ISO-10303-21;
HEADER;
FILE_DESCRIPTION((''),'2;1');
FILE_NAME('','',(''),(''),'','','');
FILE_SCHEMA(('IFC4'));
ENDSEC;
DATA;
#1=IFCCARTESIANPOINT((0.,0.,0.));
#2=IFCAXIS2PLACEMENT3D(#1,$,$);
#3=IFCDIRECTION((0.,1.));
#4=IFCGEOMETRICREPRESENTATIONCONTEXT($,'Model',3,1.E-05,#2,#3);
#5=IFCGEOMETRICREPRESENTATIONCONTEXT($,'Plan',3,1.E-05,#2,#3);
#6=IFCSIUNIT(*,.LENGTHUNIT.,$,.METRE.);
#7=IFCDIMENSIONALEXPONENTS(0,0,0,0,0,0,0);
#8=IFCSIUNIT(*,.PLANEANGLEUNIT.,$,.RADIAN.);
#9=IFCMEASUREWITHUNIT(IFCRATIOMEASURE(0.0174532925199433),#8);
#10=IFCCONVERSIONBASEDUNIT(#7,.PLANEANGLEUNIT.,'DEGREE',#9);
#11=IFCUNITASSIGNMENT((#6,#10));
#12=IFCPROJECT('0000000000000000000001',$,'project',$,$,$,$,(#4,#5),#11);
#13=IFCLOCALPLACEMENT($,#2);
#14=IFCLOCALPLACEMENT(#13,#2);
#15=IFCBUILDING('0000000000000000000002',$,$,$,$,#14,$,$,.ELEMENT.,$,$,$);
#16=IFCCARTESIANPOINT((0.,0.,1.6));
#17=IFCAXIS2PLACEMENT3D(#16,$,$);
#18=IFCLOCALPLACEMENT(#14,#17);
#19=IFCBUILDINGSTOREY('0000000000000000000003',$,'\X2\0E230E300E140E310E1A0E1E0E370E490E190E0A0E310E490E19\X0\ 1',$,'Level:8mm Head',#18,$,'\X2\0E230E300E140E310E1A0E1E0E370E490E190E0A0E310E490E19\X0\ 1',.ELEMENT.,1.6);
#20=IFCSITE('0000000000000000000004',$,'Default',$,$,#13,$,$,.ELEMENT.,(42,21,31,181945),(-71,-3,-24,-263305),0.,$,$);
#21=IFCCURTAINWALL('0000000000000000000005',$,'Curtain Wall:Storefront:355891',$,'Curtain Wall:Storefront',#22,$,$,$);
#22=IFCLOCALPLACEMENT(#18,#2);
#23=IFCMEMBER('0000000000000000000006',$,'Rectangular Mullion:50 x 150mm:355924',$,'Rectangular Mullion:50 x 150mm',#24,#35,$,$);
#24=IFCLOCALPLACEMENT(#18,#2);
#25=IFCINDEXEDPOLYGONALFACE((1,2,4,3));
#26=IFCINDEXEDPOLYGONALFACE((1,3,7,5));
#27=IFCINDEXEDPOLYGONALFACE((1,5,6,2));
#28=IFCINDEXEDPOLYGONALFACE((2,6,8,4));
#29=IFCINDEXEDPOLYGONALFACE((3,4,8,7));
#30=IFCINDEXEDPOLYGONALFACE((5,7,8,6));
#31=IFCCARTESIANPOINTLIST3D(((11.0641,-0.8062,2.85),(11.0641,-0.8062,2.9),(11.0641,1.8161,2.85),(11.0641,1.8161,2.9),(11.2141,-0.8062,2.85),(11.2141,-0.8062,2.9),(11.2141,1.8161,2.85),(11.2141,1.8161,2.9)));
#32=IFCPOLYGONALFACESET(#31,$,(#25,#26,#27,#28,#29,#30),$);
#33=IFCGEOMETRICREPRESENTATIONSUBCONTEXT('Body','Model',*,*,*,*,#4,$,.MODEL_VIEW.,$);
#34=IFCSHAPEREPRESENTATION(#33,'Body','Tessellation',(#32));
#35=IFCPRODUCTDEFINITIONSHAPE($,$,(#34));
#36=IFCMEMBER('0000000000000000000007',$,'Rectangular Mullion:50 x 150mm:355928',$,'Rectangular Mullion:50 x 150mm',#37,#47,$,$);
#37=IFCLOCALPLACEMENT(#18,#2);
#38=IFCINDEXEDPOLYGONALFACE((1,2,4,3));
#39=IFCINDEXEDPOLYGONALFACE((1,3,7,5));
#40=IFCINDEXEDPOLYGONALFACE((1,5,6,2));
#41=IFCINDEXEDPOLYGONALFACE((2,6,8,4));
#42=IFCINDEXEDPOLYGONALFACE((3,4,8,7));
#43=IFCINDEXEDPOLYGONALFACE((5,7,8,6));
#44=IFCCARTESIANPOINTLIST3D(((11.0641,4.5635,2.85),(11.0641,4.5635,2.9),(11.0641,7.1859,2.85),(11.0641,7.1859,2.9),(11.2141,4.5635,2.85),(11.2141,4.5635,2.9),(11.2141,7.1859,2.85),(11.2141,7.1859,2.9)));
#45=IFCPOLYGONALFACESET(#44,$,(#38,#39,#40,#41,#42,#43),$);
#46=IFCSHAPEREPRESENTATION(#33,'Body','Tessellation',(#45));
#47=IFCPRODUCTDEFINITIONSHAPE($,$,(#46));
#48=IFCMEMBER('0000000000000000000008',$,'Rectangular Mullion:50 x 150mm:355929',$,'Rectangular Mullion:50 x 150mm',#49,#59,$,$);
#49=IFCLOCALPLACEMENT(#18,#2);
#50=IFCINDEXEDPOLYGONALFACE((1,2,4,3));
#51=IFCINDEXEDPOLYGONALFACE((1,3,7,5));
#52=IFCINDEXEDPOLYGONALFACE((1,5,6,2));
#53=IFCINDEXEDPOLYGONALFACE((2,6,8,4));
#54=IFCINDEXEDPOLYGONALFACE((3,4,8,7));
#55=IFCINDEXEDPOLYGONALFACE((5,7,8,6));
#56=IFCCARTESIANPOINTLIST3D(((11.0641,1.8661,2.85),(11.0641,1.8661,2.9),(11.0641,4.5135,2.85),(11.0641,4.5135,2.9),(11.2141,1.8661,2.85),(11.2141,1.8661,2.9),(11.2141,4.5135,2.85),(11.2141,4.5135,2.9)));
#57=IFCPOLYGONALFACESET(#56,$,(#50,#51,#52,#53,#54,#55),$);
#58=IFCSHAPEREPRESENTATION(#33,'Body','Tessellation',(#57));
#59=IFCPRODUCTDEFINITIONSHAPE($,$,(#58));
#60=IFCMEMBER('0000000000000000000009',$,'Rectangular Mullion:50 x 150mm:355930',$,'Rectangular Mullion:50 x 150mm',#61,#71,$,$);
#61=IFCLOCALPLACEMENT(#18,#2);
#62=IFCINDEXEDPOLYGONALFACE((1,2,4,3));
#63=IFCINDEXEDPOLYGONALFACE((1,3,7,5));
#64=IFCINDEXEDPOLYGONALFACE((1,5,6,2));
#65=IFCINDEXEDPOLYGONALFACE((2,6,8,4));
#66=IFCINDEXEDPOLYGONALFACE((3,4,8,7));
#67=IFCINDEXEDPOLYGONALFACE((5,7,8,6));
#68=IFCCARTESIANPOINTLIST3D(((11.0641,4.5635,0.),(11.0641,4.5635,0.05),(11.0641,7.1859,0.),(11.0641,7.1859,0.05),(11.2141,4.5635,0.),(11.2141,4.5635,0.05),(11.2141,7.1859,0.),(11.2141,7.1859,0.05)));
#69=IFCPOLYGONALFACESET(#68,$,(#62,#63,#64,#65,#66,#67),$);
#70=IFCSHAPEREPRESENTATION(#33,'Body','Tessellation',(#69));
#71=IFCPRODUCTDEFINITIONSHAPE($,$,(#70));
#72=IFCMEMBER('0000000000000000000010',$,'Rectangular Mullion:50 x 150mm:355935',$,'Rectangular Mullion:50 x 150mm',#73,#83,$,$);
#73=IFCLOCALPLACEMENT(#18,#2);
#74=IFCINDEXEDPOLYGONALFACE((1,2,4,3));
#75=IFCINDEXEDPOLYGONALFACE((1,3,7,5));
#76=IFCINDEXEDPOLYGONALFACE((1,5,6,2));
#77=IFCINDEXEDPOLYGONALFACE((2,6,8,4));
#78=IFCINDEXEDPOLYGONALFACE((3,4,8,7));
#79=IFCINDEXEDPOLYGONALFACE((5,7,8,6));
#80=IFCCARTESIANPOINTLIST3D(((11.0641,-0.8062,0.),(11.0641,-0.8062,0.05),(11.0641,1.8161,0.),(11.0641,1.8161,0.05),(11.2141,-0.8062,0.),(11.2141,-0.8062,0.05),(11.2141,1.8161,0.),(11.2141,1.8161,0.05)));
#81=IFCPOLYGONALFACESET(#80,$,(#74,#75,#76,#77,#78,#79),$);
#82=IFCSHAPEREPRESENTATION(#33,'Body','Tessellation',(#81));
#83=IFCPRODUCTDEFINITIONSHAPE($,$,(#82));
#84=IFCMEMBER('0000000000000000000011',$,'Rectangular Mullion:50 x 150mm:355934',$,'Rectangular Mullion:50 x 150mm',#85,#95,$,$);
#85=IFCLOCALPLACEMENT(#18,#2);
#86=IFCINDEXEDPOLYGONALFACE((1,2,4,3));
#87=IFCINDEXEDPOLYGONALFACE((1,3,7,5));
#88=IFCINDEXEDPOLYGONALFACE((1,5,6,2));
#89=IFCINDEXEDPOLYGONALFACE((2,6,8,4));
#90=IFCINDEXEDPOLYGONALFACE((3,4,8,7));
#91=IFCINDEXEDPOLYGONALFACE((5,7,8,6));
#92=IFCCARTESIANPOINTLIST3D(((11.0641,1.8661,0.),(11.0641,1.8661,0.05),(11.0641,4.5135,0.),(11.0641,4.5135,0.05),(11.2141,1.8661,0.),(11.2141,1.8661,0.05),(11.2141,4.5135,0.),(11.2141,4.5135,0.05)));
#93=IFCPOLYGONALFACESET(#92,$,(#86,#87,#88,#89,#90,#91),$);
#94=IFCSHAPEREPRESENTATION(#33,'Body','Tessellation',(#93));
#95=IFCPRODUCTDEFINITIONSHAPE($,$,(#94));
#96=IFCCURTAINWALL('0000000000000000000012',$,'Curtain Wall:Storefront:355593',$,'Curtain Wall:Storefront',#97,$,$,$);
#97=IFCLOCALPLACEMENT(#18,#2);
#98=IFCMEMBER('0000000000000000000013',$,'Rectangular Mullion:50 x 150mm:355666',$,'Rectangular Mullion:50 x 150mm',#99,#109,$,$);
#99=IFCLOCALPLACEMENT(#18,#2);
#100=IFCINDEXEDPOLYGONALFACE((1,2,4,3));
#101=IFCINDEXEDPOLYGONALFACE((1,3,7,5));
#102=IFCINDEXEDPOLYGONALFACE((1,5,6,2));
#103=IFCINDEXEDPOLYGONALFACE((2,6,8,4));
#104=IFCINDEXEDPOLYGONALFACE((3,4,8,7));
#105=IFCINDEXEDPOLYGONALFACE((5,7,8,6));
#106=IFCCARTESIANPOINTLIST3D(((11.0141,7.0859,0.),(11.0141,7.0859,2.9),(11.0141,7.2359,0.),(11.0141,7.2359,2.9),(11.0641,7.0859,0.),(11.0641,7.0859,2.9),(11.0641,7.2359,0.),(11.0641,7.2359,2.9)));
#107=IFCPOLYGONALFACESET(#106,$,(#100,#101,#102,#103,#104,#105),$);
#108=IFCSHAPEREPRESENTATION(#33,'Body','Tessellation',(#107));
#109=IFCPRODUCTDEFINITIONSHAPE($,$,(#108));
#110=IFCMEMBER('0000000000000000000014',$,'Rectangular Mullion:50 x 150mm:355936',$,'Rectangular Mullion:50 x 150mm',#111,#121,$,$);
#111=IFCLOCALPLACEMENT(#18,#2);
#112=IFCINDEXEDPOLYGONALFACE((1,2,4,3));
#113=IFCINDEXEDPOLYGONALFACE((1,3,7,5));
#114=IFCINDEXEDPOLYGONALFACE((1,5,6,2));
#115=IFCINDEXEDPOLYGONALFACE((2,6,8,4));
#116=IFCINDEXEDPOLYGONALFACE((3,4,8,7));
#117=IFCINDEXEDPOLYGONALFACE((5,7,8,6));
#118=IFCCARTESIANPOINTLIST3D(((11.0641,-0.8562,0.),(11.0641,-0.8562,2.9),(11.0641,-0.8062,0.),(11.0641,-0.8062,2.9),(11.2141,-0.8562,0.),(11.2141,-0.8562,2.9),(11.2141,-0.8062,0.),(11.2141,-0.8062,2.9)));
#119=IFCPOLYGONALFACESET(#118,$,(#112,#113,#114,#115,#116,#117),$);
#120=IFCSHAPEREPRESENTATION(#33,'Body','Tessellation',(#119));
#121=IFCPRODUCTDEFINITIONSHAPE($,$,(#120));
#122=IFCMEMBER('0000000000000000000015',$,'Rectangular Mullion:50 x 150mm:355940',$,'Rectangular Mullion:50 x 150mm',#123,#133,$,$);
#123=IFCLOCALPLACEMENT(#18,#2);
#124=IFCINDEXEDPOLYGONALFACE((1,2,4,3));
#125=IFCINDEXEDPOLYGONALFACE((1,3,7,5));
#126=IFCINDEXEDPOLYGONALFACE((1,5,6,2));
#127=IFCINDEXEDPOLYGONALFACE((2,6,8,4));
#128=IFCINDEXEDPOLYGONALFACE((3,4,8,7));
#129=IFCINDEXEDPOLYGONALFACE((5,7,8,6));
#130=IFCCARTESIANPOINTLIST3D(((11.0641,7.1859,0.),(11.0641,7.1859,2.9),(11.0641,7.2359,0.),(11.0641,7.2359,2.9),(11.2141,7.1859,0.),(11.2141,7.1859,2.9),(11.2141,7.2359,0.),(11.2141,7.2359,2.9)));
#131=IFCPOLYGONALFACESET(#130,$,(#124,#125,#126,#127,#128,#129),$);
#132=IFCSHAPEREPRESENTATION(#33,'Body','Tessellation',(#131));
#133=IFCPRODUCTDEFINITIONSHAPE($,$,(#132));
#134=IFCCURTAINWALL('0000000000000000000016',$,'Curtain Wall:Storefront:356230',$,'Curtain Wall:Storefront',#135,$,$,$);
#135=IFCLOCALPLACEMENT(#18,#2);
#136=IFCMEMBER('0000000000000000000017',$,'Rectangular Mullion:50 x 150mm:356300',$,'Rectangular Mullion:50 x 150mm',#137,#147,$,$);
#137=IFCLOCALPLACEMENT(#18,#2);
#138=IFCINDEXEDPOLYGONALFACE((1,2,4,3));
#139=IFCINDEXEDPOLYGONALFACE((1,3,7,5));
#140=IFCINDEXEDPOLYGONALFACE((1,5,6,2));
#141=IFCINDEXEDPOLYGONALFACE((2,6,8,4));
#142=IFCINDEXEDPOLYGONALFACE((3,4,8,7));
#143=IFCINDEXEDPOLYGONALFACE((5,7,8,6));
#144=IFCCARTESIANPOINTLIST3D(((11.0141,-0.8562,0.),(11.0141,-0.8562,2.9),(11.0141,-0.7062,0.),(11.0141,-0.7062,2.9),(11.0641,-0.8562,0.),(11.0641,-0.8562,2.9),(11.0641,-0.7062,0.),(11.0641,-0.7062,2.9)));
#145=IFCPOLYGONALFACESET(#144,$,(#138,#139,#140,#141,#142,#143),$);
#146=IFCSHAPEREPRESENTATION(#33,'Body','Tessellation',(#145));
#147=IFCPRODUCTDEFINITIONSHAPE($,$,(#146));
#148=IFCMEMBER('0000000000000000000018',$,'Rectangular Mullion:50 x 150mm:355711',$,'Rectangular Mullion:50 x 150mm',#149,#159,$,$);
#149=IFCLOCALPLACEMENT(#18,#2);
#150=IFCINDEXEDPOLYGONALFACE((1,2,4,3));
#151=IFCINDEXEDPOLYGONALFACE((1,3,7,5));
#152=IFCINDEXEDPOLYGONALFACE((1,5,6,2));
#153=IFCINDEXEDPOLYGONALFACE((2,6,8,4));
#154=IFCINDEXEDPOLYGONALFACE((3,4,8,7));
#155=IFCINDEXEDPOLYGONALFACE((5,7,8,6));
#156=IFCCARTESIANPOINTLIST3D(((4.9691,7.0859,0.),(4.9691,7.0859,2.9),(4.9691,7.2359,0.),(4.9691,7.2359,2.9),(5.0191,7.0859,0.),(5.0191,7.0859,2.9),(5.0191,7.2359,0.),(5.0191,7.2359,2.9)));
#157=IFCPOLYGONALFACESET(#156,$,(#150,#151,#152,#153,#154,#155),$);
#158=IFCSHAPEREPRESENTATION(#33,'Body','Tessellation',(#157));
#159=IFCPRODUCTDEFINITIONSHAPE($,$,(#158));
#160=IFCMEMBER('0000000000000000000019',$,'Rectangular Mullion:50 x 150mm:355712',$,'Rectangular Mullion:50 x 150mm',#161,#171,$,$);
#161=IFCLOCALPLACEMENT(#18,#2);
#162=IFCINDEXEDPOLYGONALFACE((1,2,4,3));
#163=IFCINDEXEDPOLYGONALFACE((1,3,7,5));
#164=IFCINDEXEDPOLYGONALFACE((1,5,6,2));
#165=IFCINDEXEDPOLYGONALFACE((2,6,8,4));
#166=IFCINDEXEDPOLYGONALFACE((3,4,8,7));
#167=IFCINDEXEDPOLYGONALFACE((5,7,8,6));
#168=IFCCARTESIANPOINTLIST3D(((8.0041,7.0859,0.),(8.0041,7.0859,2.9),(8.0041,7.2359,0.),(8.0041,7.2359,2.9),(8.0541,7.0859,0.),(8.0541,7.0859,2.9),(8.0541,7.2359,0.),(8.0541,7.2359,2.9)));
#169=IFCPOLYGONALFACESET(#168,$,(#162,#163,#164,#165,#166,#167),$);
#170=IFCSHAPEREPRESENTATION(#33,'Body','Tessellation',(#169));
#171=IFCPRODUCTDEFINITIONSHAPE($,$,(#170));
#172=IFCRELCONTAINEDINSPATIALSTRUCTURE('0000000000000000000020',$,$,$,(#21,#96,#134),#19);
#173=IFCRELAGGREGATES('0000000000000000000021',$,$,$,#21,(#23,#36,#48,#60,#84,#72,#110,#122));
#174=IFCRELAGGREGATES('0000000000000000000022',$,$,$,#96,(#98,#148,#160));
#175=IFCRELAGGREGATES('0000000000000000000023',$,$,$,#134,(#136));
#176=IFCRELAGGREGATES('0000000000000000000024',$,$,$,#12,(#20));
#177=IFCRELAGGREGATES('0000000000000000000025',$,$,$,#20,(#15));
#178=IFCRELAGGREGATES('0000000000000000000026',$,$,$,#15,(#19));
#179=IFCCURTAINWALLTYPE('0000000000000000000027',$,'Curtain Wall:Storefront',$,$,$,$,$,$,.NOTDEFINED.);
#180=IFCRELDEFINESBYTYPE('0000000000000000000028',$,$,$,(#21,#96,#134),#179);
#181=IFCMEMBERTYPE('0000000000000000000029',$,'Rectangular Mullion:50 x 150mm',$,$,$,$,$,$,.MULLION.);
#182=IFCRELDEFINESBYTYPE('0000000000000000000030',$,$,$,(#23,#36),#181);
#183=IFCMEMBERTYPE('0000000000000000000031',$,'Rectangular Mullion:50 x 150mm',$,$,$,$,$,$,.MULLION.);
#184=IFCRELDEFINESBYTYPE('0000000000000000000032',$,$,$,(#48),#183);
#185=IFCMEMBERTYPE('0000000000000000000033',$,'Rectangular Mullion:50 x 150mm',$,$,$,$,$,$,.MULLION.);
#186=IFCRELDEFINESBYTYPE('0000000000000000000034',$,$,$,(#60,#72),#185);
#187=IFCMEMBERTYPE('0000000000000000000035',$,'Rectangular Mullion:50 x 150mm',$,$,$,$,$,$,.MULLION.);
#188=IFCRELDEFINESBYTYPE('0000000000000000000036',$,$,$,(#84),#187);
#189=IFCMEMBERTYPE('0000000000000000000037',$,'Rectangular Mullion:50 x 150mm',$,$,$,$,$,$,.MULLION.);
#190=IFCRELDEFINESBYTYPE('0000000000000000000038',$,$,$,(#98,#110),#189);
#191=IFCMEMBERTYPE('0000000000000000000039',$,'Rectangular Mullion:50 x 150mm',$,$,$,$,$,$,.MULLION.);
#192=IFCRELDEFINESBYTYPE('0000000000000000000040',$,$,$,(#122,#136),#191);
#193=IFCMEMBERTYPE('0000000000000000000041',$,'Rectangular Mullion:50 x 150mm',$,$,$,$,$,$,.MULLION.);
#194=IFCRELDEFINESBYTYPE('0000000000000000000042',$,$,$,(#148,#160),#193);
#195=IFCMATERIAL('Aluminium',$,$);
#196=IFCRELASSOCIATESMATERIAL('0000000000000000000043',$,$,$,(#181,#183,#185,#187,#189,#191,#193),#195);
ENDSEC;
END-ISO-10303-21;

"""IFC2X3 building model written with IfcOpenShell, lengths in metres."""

from ifc_helpers import new_model, entity, si_unit, converted_unit, direction, frame, origin, origin_2d_with_axis, place, context, subcontext, project, spatial, rectangle, extrude, source, transform, mapped, material, type_object, type_shapes, element, aggregate, save


model = new_model("IFC2X3")

# Units and contexts
model_context = context("Model", 3, precision=1e-05, world=origin(), true_north=direction((0.0, 1.0)))
plan_context = context("Plan", 3, precision=1e-05, world=origin(), true_north=direction((0.0, 1.0)))
body_context = subcontext(model_context, "Body", "Model", "MODEL_VIEW")
ifc_project = project(units=[si_unit("LENGTHUNIT", "METRE"), converted_unit("PLANEANGLEUNIT", "DEGREE", entity("IfcRatioMeasure", 0.0174532925199433), si_unit("PLANEANGLEUNIT", "RADIAN"), dimensions=[0, 0, 0, 0, 0, 0, 0])], contexts=[model_context, plan_context])

# Site, building, storey
site_placement = place(None, origin())
site = spatial("IfcSite", under=ifc_project, at=site_placement, Name="Default", CompositionType="ELEMENT", RefLatitude=(42, 21, 31, 181945), RefLongitude=(-71, -3, -24, -263305), RefElevation=0.0)
building_placement = place(site_placement, origin())
building = spatial("IfcBuilding", under=site, at=building_placement, CompositionType="ELEMENT")
storey_placement = place(building_placement, frame((0.0, 0.0, 1.6)))
storey = spatial("IfcBuildingStorey", under=building, at=storey_placement, Name="ระดับพื้นชั้น 1", ObjectType="Level:8mm Head", LongName="ระดับพื้นชั้น 1", CompositionType="ELEMENT", Elevation=1.6)

# Curtain wall, members
curtain_wall_type = type_object("IfcCurtainWallType", Name="Curtain Wall:Storefront", PredefinedType="NOTDEFINED")
curtain_wall_1_placement = place(storey_placement, frame((0.0, 0.0, -1.6)))
curtain_wall_1 = element("IfcCurtainWall", 1, at=curtain_wall_1_placement, inside=storey, type_object=curtain_wall_type, Name="Curtain Wall:Storefront:355891", ObjectType="Curtain Wall:Storefront")
ifc_material_1 = material(Name="Aluminium")
member_type_1 = type_object("IfcMemberType", Name="Rectangular Mullion:50 x 150mm", PredefinedType="MULLION", material=ifc_material_1)
shared_shape_1 = source(origin(), body_context, "Body", "SweptSolid", [
    extrude(rectangle(XDim=0.15, YDim=0.05, at=origin_2d_with_axis()), frame((-0.025, 0.0, -2.6224), z_axis=(0.0, 0.0, 1.0), x_axis=(0.0, -1.0, 0.0)), (0.0, 0.0, 1.0), 2.6224),
])
type_shapes(member_type_1, [shared_shape_1])
member_1_placement = place(curtain_wall_1_placement, frame((11.1391, -0.8062, 4.5), z_axis=(0.0, -1.0, 0.0), x_axis=(0.0, 0.0, 1.0)))
member_1 = element("IfcMember", 2, at=member_1_placement, type_object=member_type_1, Name="Rectangular Mullion:50 x 150mm:355924", ObjectType="Rectangular Mullion:50 x 150mm", context=body_context, shape_type="MappedRepresentation", body=[
    mapped(shared_shape_1, transform((0.0, 0.0, 0.0), scale=1.0)),
])
member_2_placement = place(curtain_wall_1_placement, frame((11.1391, 4.5635, 4.5), z_axis=(0.0, -1.0, 0.0), x_axis=(0.0, 0.0, 1.0)))
member_2 = element("IfcMember", 3, at=member_2_placement, type_object=member_type_1, Name="Rectangular Mullion:50 x 150mm:355928", ObjectType="Rectangular Mullion:50 x 150mm", context=body_context, shape_type="MappedRepresentation", body=[
    mapped(shared_shape_1, transform((0.0, 0.0, 0.0), scale=1.0)),
])
member_type_2 = type_object("IfcMemberType", Name="Rectangular Mullion:50 x 150mm", PredefinedType="MULLION", material=ifc_material_1)
shared_shape_2 = source(origin(), body_context, "Body", "SweptSolid", [
    extrude(rectangle(XDim=0.15, YDim=0.05, at=origin_2d_with_axis()), frame((-0.025, 0.0, -2.6474), z_axis=(0.0, 0.0, 1.0), x_axis=(0.0, -1.0, 0.0)), (0.0, 0.0, 1.0), 2.6474),
])
type_shapes(member_type_2, [shared_shape_2])
member_3_placement = place(curtain_wall_1_placement, frame((11.1391, 1.8661, 4.5), z_axis=(0.0, -1.0, 0.0), x_axis=(0.0, 0.0, 1.0)))
member_3 = element("IfcMember", 4, at=member_3_placement, type_object=member_type_2, Name="Rectangular Mullion:50 x 150mm:355929", ObjectType="Rectangular Mullion:50 x 150mm", context=body_context, shape_type="MappedRepresentation", body=[
    mapped(shared_shape_2, transform((0.0, 0.0, 0.0), scale=1.0)),
])
member_type_3 = type_object("IfcMemberType", Name="Rectangular Mullion:50 x 150mm", PredefinedType="MULLION", material=ifc_material_1)
shared_shape_3 = source(origin(), body_context, "Body", "SweptSolid", [
    extrude(rectangle(XDim=0.15, YDim=0.05, at=origin_2d_with_axis()), frame((-0.025, 0.0, -2.6224), z_axis=(0.0, 0.0, 1.0), x_axis=(0.0, -1.0, 0.0)), (0.0, 0.0, 1.0), 2.6224),
])
type_shapes(member_type_3, [shared_shape_3])
member_4_placement = place(curtain_wall_1_placement, frame((11.1391, 7.1859, 1.6), z_axis=(0.0, 1.0, 0.0), x_axis=(0.0, 0.0, -1.0)))
member_4 = element("IfcMember", 5, at=member_4_placement, type_object=member_type_3, Name="Rectangular Mullion:50 x 150mm:355930", ObjectType="Rectangular Mullion:50 x 150mm", context=body_context, shape_type="MappedRepresentation", body=[
    mapped(shared_shape_3, transform((0.0, 0.0, 0.0), scale=1.0)),
])
member_5_placement = place(curtain_wall_1_placement, frame((11.1391, 1.8161, 1.6), z_axis=(0.0, 1.0, 0.0), x_axis=(0.0, 0.0, -1.0)))
member_5 = element("IfcMember", 6, at=member_5_placement, type_object=member_type_3, Name="Rectangular Mullion:50 x 150mm:355935", ObjectType="Rectangular Mullion:50 x 150mm", context=body_context, shape_type="MappedRepresentation", body=[
    mapped(shared_shape_3, transform((0.0, 0.0, 0.0), scale=1.0)),
])
member_type_4 = type_object("IfcMemberType", Name="Rectangular Mullion:50 x 150mm", PredefinedType="MULLION", material=ifc_material_1)
shared_shape_4 = source(origin(), body_context, "Body", "SweptSolid", [
    extrude(rectangle(XDim=0.15, YDim=0.05, at=origin_2d_with_axis()), frame((-0.025, 0.0, -2.6474), z_axis=(0.0, 0.0, 1.0), x_axis=(0.0, -1.0, 0.0)), (0.0, 0.0, 1.0), 2.6474),
])
type_shapes(member_type_4, [shared_shape_4])
member_6_placement = place(curtain_wall_1_placement, frame((11.1391, 4.5135, 1.6), z_axis=(0.0, 1.0, 0.0), x_axis=(0.0, 0.0, -1.0)))
member_6 = element("IfcMember", 7, at=member_6_placement, type_object=member_type_4, Name="Rectangular Mullion:50 x 150mm:355934", ObjectType="Rectangular Mullion:50 x 150mm", context=body_context, shape_type="MappedRepresentation", body=[
    mapped(shared_shape_4, transform((0.0, 0.0, 0.0), scale=1.0)),
])

# Curtain wall, member
curtain_wall_2_placement = place(storey_placement, frame((0.0, 0.0, -1.6)))
curtain_wall_2 = element("IfcCurtainWall", 8, at=curtain_wall_2_placement, inside=storey, type_object=curtain_wall_type, Name="Curtain Wall:Storefront:355593", ObjectType="Curtain Wall:Storefront")
member_type_5 = type_object("IfcMemberType", Name="Rectangular Mullion:50 x 150mm", PredefinedType="MULLION", material=ifc_material_1)
shared_shape_5 = source(origin(), body_context, "Body", "SweptSolid", [
    extrude(rectangle(XDim=0.15, YDim=0.05, at=origin_2d_with_axis()), frame((-0.025, 0.0, -2.9), z_axis=(0.0, 0.0, 1.0), x_axis=(0.0, -1.0, 0.0)), (0.0, 0.0, 1.0), 2.9),
])
type_shapes(member_type_5, [shared_shape_5])
member_7_placement = place(curtain_wall_2_placement, frame((11.0641, 7.1609, 1.6), z_axis=(0.0, 0.0, -1.0), x_axis=(1.0, 0.0, 0.0)))
member_7 = element("IfcMember", 9, at=member_7_placement, type_object=member_type_5, Name="Rectangular Mullion:50 x 150mm:355666", ObjectType="Rectangular Mullion:50 x 150mm", context=body_context, shape_type="MappedRepresentation", body=[
    mapped(shared_shape_5, transform((0.0, 0.0, 0.0), scale=1.0)),
])

# Members
member_8_placement = place(curtain_wall_1_placement, frame((11.1391, -0.8562, 1.6), z_axis=(0.0, 0.0, -1.0), x_axis=(0.0, -1.0, 0.0)))
member_8 = element("IfcMember", 10, at=member_8_placement, type_object=member_type_5, Name="Rectangular Mullion:50 x 150mm:355936", ObjectType="Rectangular Mullion:50 x 150mm", context=body_context, shape_type="MappedRepresentation", body=[
    mapped(shared_shape_5, transform((0.0, 0.0, 0.0), scale=1.0)),
])
member_type_6 = type_object("IfcMemberType", Name="Rectangular Mullion:50 x 150mm", PredefinedType="MULLION", material=ifc_material_1)
shared_shape_6 = source(origin(), body_context, "Body", "SweptSolid", [
    extrude(rectangle(XDim=0.15, YDim=0.05, at=origin_2d_with_axis()), frame((-0.025, 0.0, -2.9), z_axis=(0.0, 0.0, 1.0), x_axis=(0.0, -1.0, 0.0)), (0.0, 0.0, 1.0), 2.9),
])
type_shapes(member_type_6, [shared_shape_6])
member_9_placement = place(curtain_wall_1_placement, frame((11.1391, 7.2359, 4.5), z_axis=(0.0, 0.0, 1.0), x_axis=(0.0, 1.0, 0.0)))
member_9 = element("IfcMember", 11, at=member_9_placement, type_object=member_type_6, Name="Rectangular Mullion:50 x 150mm:355940", ObjectType="Rectangular Mullion:50 x 150mm", context=body_context, shape_type="MappedRepresentation", body=[
    mapped(shared_shape_6, transform((0.0, 0.0, 0.0), scale=1.0)),
])

# Curtain wall, member
curtain_wall_3_placement = place(storey_placement, frame((0.0, 0.0, -1.6)))
curtain_wall_3 = element("IfcCurtainWall", 12, at=curtain_wall_3_placement, inside=storey, type_object=curtain_wall_type, Name="Curtain Wall:Storefront:356230", ObjectType="Curtain Wall:Storefront")
member_10_placement = place(curtain_wall_3_placement, frame((11.0641, -0.7812, 4.5)))
member_10 = element("IfcMember", 13, at=member_10_placement, type_object=member_type_6, Name="Rectangular Mullion:50 x 150mm:356300", ObjectType="Rectangular Mullion:50 x 150mm", context=body_context, shape_type="MappedRepresentation", body=[
    mapped(shared_shape_6, transform((0.0, 0.0, 0.0), scale=1.0)),
])

# Members
member_type_7 = type_object("IfcMemberType", Name="Rectangular Mullion:50 x 150mm", PredefinedType="MULLION", material=ifc_material_1)
shared_shape_7 = source(origin(), body_context, "Body", "SweptSolid", [
    extrude(rectangle(XDim=0.15, YDim=0.05, at=origin_2d_with_axis()), frame((0.0, 0.0, -2.9), z_axis=(0.0, 0.0, 1.0), x_axis=(0.0, -1.0, 0.0)), (0.0, 0.0, 1.0), 2.9),
])
type_shapes(member_type_7, [shared_shape_7])
member_11_placement = place(curtain_wall_2_placement, frame((4.9941, 7.1609, 1.6), z_axis=(0.0, 0.0, -1.0), x_axis=(1.0, 0.0, 0.0)))
member_11 = element("IfcMember", 14, at=member_11_placement, type_object=member_type_7, Name="Rectangular Mullion:50 x 150mm:355711", ObjectType="Rectangular Mullion:50 x 150mm", context=body_context, shape_type="MappedRepresentation", body=[
    mapped(shared_shape_7, transform((0.0, 0.0, 0.0), scale=1.0)),
])
member_12_placement = place(curtain_wall_2_placement, frame((8.0291, 7.1609, 1.6), z_axis=(0.0, 0.0, -1.0), x_axis=(1.0, 0.0, 0.0)))
member_12 = element("IfcMember", 15, at=member_12_placement, type_object=member_type_7, Name="Rectangular Mullion:50 x 150mm:355712", ObjectType="Rectangular Mullion:50 x 150mm", context=body_context, shape_type="MappedRepresentation", body=[
    mapped(shared_shape_7, transform((0.0, 0.0, 0.0), scale=1.0)),
])

aggregate(curtain_wall_1, [member_1, member_2, member_3, member_4, member_6, member_5, member_8, member_9])
aggregate(curtain_wall_2, [member_7, member_11, member_12])
aggregate(curtain_wall_3, [member_10])

save(model, "model.ifc")
